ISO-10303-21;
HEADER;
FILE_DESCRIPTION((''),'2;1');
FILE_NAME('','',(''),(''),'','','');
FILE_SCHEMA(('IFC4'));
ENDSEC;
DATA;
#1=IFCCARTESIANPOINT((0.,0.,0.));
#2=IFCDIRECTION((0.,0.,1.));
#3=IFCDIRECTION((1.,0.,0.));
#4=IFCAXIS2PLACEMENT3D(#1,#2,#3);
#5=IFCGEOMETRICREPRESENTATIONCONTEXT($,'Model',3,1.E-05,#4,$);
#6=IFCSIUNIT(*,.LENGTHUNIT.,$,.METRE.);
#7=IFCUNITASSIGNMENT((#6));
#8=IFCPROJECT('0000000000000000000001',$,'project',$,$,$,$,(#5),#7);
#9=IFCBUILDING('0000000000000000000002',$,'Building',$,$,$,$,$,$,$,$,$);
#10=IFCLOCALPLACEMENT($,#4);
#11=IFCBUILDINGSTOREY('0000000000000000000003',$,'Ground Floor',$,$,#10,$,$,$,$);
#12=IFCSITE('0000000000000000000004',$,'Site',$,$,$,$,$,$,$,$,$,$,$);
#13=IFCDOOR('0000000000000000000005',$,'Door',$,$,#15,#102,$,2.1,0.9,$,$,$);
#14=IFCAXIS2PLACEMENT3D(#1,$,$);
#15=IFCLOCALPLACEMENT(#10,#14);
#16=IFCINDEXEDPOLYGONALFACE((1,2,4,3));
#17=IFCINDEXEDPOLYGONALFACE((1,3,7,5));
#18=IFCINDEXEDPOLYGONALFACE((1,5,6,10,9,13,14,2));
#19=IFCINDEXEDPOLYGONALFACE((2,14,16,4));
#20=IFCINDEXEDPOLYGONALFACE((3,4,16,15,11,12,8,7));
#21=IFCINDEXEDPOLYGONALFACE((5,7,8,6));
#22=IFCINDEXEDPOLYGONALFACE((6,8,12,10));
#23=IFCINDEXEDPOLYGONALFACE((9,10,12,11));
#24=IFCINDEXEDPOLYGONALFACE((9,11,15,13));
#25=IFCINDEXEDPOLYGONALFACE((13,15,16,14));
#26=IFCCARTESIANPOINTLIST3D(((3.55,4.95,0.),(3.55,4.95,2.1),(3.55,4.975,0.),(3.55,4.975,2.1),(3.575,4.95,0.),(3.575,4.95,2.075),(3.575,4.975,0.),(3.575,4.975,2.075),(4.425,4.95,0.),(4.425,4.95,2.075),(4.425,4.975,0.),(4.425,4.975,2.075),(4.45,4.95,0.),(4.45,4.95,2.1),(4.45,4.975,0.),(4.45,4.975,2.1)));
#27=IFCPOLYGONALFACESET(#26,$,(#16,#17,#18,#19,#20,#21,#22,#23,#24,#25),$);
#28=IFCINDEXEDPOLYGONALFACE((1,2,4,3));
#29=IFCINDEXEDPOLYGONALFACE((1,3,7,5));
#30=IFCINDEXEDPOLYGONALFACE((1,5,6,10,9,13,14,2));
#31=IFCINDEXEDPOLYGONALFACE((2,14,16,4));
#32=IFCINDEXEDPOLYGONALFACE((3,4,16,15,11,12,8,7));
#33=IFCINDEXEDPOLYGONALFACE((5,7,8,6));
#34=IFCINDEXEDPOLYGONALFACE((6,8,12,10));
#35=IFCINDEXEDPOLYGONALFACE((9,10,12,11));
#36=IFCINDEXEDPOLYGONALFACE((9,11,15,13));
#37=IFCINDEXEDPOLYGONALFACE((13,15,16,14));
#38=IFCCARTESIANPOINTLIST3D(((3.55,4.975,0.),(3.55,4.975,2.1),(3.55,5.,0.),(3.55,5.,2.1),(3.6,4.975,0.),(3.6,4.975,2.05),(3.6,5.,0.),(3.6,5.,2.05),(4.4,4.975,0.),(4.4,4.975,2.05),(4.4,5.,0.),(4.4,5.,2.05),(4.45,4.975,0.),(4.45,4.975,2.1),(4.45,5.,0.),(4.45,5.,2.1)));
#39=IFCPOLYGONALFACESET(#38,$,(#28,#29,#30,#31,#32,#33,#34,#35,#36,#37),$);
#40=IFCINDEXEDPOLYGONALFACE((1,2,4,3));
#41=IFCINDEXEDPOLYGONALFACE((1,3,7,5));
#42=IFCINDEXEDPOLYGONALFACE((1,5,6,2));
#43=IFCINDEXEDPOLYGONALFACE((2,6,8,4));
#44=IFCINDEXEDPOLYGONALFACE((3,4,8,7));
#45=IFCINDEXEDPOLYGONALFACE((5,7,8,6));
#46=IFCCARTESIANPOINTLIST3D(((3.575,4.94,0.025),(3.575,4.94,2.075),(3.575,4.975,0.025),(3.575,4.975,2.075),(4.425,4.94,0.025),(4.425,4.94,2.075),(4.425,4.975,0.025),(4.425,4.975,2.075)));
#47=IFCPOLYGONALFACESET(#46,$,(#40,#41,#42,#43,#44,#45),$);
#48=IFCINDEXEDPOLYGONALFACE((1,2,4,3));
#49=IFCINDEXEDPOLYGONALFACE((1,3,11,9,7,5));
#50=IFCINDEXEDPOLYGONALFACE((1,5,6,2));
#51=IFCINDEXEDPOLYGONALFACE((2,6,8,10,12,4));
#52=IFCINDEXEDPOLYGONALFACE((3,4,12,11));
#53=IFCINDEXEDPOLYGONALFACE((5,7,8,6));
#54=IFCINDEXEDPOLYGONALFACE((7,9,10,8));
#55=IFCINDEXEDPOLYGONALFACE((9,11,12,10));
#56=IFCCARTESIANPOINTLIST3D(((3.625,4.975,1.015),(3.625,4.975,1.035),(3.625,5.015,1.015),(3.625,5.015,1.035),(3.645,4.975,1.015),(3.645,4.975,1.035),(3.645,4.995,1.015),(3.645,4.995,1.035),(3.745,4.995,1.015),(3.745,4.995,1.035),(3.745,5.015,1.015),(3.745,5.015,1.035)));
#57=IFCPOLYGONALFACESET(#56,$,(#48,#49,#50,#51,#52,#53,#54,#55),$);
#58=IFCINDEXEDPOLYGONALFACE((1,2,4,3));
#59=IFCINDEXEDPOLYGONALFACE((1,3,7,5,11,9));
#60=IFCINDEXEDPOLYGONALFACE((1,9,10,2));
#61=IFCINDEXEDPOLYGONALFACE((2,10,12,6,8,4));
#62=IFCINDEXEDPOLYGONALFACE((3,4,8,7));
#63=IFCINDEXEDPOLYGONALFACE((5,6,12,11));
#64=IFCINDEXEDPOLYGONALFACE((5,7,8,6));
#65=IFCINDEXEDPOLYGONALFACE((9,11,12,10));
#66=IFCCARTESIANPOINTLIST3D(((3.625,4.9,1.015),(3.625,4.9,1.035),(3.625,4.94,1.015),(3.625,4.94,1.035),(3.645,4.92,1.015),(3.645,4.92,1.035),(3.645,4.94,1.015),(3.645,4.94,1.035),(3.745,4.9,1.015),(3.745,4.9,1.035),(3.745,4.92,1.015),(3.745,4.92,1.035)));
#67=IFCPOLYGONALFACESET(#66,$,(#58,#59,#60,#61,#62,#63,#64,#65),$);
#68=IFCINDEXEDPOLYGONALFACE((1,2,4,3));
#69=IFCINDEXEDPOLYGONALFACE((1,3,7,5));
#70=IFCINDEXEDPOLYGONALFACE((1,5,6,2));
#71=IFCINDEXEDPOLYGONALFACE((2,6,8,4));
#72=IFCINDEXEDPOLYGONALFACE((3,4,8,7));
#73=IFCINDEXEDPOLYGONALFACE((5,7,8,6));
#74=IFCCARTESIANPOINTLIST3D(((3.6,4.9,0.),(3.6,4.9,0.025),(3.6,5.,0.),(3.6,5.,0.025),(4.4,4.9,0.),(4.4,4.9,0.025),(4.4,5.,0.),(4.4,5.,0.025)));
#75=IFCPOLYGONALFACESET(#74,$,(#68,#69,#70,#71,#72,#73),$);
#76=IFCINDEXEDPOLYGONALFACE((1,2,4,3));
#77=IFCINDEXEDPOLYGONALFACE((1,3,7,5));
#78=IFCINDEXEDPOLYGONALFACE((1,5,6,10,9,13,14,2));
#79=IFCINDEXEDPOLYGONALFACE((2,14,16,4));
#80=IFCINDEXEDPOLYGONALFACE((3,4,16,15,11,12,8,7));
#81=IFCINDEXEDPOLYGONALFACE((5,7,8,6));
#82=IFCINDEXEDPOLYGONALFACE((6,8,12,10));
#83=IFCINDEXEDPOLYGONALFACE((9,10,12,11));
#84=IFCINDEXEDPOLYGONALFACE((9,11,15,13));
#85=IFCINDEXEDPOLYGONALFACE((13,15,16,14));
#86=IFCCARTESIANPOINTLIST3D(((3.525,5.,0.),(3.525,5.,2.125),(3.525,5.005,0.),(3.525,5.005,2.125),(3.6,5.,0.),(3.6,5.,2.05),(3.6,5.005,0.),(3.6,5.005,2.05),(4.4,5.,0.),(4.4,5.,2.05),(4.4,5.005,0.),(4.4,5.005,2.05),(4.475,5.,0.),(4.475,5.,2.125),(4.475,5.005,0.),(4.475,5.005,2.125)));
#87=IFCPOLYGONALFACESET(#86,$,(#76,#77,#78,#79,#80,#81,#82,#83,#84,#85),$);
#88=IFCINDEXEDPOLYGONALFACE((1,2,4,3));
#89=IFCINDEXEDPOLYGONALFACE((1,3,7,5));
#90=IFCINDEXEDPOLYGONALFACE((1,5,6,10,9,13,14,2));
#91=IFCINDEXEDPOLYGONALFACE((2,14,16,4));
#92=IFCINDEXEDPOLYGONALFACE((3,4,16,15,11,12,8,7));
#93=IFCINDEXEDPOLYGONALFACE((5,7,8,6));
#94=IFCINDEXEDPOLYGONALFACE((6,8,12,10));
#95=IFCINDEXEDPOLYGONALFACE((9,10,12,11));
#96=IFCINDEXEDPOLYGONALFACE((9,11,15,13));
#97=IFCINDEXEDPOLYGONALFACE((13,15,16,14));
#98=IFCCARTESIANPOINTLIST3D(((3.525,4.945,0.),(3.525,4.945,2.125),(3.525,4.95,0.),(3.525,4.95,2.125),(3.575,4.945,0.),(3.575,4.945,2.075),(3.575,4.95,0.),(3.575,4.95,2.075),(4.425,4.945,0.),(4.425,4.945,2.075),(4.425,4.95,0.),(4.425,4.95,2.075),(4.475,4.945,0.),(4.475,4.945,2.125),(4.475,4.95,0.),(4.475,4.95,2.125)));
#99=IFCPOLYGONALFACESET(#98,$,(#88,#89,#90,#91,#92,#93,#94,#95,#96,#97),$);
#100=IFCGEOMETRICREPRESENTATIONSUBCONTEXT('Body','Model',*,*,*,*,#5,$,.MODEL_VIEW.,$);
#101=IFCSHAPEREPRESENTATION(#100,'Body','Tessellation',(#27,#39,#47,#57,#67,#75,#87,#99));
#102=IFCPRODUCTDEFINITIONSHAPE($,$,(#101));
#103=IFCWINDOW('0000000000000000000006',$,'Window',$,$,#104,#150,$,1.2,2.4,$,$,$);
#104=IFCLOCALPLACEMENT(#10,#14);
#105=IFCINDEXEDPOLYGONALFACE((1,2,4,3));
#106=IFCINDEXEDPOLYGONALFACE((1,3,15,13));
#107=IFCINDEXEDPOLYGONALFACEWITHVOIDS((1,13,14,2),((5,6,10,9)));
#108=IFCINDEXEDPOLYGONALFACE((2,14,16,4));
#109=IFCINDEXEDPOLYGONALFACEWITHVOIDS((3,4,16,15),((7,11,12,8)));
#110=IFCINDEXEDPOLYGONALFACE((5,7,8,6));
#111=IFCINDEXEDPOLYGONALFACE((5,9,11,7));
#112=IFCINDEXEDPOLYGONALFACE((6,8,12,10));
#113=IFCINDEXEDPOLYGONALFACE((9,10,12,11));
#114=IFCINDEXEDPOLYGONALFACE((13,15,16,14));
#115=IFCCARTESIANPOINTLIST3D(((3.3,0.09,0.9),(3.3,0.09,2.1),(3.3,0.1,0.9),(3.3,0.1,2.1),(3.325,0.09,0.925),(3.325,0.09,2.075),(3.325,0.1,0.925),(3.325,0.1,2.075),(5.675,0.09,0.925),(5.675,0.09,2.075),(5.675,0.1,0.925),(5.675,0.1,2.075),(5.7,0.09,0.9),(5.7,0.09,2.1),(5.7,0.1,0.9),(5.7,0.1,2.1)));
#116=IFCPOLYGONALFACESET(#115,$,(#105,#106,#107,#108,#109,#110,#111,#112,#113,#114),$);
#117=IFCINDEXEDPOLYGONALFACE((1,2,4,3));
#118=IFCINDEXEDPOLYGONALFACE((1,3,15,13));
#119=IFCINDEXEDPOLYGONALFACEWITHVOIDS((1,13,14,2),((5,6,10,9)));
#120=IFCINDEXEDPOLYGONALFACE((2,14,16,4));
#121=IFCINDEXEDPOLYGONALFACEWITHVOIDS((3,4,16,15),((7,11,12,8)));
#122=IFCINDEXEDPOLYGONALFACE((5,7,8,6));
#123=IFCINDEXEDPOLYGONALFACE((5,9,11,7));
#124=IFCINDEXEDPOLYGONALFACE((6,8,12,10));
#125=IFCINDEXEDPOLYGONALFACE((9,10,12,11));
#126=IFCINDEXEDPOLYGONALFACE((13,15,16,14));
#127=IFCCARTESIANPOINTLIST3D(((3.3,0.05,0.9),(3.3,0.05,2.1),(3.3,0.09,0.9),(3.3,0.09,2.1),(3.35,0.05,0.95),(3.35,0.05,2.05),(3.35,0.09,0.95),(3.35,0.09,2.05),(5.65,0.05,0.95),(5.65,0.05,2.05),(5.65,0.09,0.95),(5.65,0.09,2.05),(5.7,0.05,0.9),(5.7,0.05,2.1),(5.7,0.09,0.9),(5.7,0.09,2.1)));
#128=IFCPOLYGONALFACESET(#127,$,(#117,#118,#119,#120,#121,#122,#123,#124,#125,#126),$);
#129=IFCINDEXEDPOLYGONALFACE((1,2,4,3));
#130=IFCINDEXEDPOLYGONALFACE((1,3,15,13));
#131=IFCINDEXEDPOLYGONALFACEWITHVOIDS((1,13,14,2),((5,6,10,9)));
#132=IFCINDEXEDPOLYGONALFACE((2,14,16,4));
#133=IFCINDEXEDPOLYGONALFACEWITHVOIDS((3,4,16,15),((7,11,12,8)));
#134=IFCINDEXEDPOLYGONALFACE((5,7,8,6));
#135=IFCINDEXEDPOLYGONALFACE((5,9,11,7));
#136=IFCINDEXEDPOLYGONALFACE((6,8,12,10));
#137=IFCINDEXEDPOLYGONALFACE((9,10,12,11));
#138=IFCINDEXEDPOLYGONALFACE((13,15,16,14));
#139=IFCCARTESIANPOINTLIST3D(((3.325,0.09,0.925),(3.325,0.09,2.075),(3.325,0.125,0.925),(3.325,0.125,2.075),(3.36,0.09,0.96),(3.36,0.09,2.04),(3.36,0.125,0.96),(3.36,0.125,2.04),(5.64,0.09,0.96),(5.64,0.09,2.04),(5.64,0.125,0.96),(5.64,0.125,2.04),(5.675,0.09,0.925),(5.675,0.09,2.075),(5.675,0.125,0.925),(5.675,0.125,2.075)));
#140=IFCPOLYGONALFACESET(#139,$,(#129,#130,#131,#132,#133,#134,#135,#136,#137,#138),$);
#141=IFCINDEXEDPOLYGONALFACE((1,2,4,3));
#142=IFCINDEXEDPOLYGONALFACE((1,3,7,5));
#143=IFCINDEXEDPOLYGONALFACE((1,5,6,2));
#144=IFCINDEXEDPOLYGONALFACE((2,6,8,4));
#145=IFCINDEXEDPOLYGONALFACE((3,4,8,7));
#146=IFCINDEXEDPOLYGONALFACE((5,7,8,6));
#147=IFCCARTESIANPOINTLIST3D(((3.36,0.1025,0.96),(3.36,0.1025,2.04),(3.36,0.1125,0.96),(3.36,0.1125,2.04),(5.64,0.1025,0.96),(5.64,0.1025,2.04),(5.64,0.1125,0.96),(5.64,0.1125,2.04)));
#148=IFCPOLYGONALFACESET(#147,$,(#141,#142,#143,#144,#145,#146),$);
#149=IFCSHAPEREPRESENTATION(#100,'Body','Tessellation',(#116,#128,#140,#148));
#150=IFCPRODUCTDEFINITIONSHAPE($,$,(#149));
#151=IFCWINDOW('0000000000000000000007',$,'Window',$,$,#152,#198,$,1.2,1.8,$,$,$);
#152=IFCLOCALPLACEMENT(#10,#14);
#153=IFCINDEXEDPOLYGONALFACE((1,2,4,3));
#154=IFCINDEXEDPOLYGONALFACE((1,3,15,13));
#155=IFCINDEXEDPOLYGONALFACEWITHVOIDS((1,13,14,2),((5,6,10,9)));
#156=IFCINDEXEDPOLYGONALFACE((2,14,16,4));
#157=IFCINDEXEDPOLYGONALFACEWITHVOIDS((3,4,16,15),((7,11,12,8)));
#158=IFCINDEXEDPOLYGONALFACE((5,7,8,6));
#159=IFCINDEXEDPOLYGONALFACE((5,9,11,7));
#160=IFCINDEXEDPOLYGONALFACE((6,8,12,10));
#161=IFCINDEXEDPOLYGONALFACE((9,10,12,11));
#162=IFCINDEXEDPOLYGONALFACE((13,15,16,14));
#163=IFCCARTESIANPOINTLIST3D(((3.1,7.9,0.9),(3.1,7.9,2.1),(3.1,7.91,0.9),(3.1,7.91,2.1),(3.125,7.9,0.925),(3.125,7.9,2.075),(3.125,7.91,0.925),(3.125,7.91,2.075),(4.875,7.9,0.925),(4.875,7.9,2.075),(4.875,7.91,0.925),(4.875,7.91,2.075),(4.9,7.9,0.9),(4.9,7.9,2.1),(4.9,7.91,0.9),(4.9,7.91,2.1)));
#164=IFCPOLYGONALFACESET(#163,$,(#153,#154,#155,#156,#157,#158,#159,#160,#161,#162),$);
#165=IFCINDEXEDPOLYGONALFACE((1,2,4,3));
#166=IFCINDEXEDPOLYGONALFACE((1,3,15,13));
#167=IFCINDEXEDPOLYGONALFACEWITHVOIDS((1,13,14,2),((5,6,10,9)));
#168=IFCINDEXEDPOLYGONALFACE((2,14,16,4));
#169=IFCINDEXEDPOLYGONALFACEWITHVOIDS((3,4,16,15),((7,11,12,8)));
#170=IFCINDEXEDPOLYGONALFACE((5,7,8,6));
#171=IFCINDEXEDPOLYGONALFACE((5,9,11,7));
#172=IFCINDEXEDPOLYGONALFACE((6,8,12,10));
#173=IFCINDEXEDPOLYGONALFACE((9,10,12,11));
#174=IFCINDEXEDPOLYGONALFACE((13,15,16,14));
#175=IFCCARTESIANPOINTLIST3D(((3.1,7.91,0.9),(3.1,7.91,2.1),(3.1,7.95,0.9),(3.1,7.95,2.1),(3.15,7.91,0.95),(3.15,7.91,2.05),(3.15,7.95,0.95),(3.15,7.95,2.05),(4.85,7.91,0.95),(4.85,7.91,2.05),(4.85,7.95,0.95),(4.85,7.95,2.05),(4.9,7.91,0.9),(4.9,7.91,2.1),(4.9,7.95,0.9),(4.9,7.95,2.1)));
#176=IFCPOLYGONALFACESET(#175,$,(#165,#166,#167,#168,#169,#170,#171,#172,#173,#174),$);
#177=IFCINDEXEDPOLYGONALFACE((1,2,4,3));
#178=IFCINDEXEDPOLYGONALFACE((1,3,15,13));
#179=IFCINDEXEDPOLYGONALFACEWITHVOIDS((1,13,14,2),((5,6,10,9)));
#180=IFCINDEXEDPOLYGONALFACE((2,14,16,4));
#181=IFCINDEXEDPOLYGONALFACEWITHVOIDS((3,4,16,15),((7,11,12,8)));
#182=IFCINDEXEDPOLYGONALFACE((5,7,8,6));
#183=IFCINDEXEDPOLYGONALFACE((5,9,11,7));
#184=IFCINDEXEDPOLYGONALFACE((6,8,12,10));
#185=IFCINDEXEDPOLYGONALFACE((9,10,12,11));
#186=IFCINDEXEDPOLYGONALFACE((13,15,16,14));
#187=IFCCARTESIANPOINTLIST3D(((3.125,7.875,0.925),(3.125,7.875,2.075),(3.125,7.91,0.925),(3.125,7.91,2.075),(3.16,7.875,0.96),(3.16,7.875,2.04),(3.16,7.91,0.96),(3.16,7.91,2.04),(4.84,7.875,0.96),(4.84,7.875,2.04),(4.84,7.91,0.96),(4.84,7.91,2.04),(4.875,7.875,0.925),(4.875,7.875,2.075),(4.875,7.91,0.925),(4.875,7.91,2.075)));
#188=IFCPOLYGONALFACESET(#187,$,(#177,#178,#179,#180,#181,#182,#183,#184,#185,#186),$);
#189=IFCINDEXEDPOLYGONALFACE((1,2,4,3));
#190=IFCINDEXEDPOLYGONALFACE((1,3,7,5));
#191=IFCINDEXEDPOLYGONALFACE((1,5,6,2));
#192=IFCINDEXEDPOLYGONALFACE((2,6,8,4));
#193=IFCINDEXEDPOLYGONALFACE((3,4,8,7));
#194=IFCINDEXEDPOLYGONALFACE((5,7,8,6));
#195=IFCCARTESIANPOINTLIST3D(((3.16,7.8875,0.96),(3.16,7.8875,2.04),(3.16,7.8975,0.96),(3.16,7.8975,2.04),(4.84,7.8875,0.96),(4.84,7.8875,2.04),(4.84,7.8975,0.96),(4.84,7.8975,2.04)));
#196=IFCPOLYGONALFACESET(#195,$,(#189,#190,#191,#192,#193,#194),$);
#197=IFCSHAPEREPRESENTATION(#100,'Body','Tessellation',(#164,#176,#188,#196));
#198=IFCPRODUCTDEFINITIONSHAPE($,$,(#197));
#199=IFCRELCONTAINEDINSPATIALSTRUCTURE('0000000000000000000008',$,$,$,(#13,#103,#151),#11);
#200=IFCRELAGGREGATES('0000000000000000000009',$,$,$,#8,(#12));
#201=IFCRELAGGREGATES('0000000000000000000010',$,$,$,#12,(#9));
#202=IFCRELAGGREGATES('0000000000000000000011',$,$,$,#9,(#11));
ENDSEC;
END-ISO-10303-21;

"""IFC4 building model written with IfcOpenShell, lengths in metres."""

from ifc_helpers import new_model, si_unit, frame, origin_with_axes, place, context, subcontext, project, spatial, line, indexed_curve, outline, extrude, element, save


model = new_model("IFC4")

# Units and contexts
model_context = context("Model", 3, precision=1e-05, world=origin_with_axes())
body_context = subcontext(model_context, "Body", "Model", "MODEL_VIEW")
ifc_project = project(units=[si_unit("LENGTHUNIT", "METRE")], contexts=[model_context])

# Site, building, storey
site = spatial("IfcSite", under=ifc_project, Name="Site")
building = spatial("IfcBuilding", under=site, Name="Building")
storey_placement = place(None, origin_with_axes())
storey = spatial("IfcBuildingStorey", under=building, at=storey_placement, Name="Ground Floor")

# Door
door_1_placement = place(storey_placement, frame((4.45, 5.0, 0.0), z_axis=(0.0, 0.0, 1.0), x_axis=(-1.0, 0.0, 0.0)))
element("IfcDoor", 1, at=door_1_placement, inside=storey, Name="Door", OverallHeight=2.1, OverallWidth=0.9, context=body_context, shape_type="SweptSolid", body=[
    extrude(outline(indexed_curve([(0.0, 0.0), (0.0, 2.1), (0.9, 2.1), (0.9, 0.0), (0.875, 0.0), (0.875, 2.075), (0.025, 2.075), (0.025, 0.0)], segments=[line(1, 2, 3, 4, 5, 6, 7, 8, 1)])), frame((0.0, 0.025, 0.0), z_axis=(0.0, -1.0, 0.0), x_axis=(1.0, 0.0, 0.0)), (0.0, 0.0, -1.0), 0.025),
    extrude(outline(indexed_curve([(0.0, 0.0), (0.0, 2.1), (0.9, 2.1), (0.9, 0.0), (0.85, 0.0), (0.85, 2.05), (0.05, 2.05), (0.05, 0.0)], segments=[line(1, 2, 3, 4, 5, 6, 7, 8, 1)])), frame((0.0, 0.0, 0.0), z_axis=(0.0, -1.0, 0.0), x_axis=(1.0, 0.0, 0.0)), (0.0, 0.0, -1.0), 0.025),
    extrude(outline(indexed_curve([(0.0, 0.0), (0.85, 0.0), (0.85, 0.035), (0.0, 0.035)], segments=[line(1, 2, 3, 4, 1)])), frame((0.025, 0.025, 0.025), z_axis=(0.0, 0.0, 1.0), x_axis=(1.0, 0.0, 0.0)), (0.0, 0.0, 1.0), 2.05),
    extrude(outline(indexed_curve([(0.0, 0.0), (0.0, -0.04), (-0.12, -0.04), (-0.12, -0.02), (-0.02, -0.02), (-0.02, 0.0)], segments=[line(1, 2, 3, 4, 5, 6, 1)])), frame((0.825, 0.025, 1.015), z_axis=(0.0, 0.0, 1.0), x_axis=(1.0, 0.0, 0.0)), (0.0, 0.0, 1.0), 0.02),
    extrude(outline(indexed_curve([(0.0, 0.0), (0.0, 0.04), (-0.12, 0.04), (-0.12, 0.02), (-0.02, 0.02), (-0.02, 0.0)], segments=[line(1, 2, 3, 4, 5, 6, 1)])), frame((0.825, 0.06, 1.015), z_axis=(0.0, 0.0, 1.0), x_axis=(1.0, 0.0, 0.0)), (0.0, 0.0, 1.0), 0.02),
    extrude(outline(indexed_curve([(0.0, 0.0), (0.8, 0.0), (0.8, 0.1), (0.0, 0.1)], segments=[line(1, 2, 3, 4, 1)])), frame((0.05, 0.0, 0.0), z_axis=(0.0, 0.0, 1.0), x_axis=(1.0, 0.0, 0.0)), (0.0, 0.0, 1.0), 0.025),
    extrude(outline(indexed_curve([(0.0, 0.0), (0.0, 2.125), (0.95, 2.125), (0.95, 0.0), (0.875, 0.0), (0.875, 2.05), (0.075, 2.05), (0.075, 0.0)], segments=[line(1, 2, 3, 4, 5, 6, 7, 8, 1)])), frame((-0.025, -0.005, 0.0), z_axis=(0.0, -1.0, 0.0), x_axis=(1.0, 0.0, 0.0)), (0.0, 0.0, -1.0), 0.005),
    extrude(outline(indexed_curve([(0.0, 0.0), (0.0, 2.125), (0.95, 2.125), (0.95, 0.0), (0.9, 0.0), (0.9, 2.075), (0.05, 2.075), (0.05, 0.0)], segments=[line(1, 2, 3, 4, 5, 6, 7, 8, 1)])), frame((-0.025, 0.05, 0.0), z_axis=(0.0, -1.0, 0.0), x_axis=(1.0, 0.0, 0.0)), (0.0, 0.0, -1.0), 0.005),
])

# Windows
window_1_placement = place(storey_placement, frame((3.3, 0.0, 0.9), z_axis=(0.0, 0.0, 1.0), x_axis=(1.0, 0.0, 0.0)))
element("IfcWindow", 2, at=window_1_placement, inside=storey, Name="Window", OverallHeight=1.2, OverallWidth=2.4, context=body_context, shape_type="SweptSolid", body=[
    extrude(outline(indexed_curve([(0.0, 0.0), (2.4, 0.0), (2.4, 1.2), (0.0, 1.2)], segments=[line(1, 2, 3, 4, 1)]), holes=[indexed_curve([(0.025, 0.025), (2.375, 0.025), (2.375, 1.175), (0.025, 1.175)], segments=[line(1, 2, 3, 4, 1)])]), frame((0.0, 0.09, 0.0), z_axis=(0.0, -1.0, 0.0), x_axis=(1.0, 0.0, 0.0)), (0.0, 0.0, -1.0), 0.01),
    extrude(outline(indexed_curve([(0.0, 0.0), (2.4, 0.0), (2.4, 1.2), (0.0, 1.2)], segments=[line(1, 2, 3, 4, 1)]), holes=[indexed_curve([(0.05, 0.05), (2.35, 0.05), (2.35, 1.15), (0.05, 1.15)], segments=[line(1, 2, 3, 4, 1)])]), frame((0.0, 0.05, 0.0), z_axis=(0.0, -1.0, 0.0), x_axis=(1.0, 0.0, 0.0)), (0.0, 0.0, -1.0), 0.04),
    extrude(outline(indexed_curve([(0.0, 0.0), (2.35, 0.0), (2.35, 1.15), (0.0, 1.15)], segments=[line(1, 2, 3, 4, 1)]), holes=[indexed_curve([(0.035, 0.035), (2.315, 0.035), (2.315, 1.115), (0.035, 1.115)], segments=[line(1, 2, 3, 4, 1)])]), frame((0.025, 0.09, 0.025), z_axis=(0.0, -1.0, 0.0), x_axis=(1.0, 0.0, 0.0)), (0.0, 0.0, -1.0), 0.035),
    extrude(outline(indexed_curve([(0.035, 0.035), (2.315, 0.035), (2.315, 1.115), (0.035, 1.115)], segments=[line(1, 2, 3, 4, 1)])), frame((0.025, 0.1025, 0.025), z_axis=(0.0, -1.0, 0.0), x_axis=(1.0, 0.0, 0.0)), (0.0, 0.0, -1.0), 0.01),
])
window_2_placement = place(storey_placement, frame((4.9, 8.0, 0.9), z_axis=(0.0, 0.0, 1.0), x_axis=(-1.0, 0.0, 0.0)))
element("IfcWindow", 3, at=window_2_placement, inside=storey, Name="Window", OverallHeight=1.2, OverallWidth=1.8, context=body_context, shape_type="SweptSolid", body=[
    extrude(outline(indexed_curve([(0.0, 0.0), (1.8, 0.0), (1.8, 1.2), (0.0, 1.2)], segments=[line(1, 2, 3, 4, 1)]), holes=[indexed_curve([(0.025, 0.025), (1.775, 0.025), (1.775, 1.175), (0.025, 1.175)], segments=[line(1, 2, 3, 4, 1)])]), frame((0.0, 0.09, 0.0), z_axis=(0.0, -1.0, 0.0), x_axis=(1.0, 0.0, 0.0)), (0.0, 0.0, -1.0), 0.01),
    extrude(outline(indexed_curve([(0.0, 0.0), (1.8, 0.0), (1.8, 1.2), (0.0, 1.2)], segments=[line(1, 2, 3, 4, 1)]), holes=[indexed_curve([(0.05, 0.05), (1.75, 0.05), (1.75, 1.15), (0.05, 1.15)], segments=[line(1, 2, 3, 4, 1)])]), frame((0.0, 0.05, 0.0), z_axis=(0.0, -1.0, 0.0), x_axis=(1.0, 0.0, 0.0)), (0.0, 0.0, -1.0), 0.04),
    extrude(outline(indexed_curve([(0.0, 0.0), (1.75, 0.0), (1.75, 1.15), (0.0, 1.15)], segments=[line(1, 2, 3, 4, 1)]), holes=[indexed_curve([(0.035, 0.035), (1.715, 0.035), (1.715, 1.115), (0.035, 1.115)], segments=[line(1, 2, 3, 4, 1)])]), frame((0.025, 0.09, 0.025), z_axis=(0.0, -1.0, 0.0), x_axis=(1.0, 0.0, 0.0)), (0.0, 0.0, -1.0), 0.035),
    extrude(outline(indexed_curve([(0.035, 0.035), (1.715, 0.035), (1.715, 1.115), (0.035, 1.115)], segments=[line(1, 2, 3, 4, 1)])), frame((0.025, 0.1025, 0.025), z_axis=(0.0, -1.0, 0.0), x_axis=(1.0, 0.0, 0.0)), (0.0, 0.0, -1.0), 0.01),
])

save(model, "model.ifc")
